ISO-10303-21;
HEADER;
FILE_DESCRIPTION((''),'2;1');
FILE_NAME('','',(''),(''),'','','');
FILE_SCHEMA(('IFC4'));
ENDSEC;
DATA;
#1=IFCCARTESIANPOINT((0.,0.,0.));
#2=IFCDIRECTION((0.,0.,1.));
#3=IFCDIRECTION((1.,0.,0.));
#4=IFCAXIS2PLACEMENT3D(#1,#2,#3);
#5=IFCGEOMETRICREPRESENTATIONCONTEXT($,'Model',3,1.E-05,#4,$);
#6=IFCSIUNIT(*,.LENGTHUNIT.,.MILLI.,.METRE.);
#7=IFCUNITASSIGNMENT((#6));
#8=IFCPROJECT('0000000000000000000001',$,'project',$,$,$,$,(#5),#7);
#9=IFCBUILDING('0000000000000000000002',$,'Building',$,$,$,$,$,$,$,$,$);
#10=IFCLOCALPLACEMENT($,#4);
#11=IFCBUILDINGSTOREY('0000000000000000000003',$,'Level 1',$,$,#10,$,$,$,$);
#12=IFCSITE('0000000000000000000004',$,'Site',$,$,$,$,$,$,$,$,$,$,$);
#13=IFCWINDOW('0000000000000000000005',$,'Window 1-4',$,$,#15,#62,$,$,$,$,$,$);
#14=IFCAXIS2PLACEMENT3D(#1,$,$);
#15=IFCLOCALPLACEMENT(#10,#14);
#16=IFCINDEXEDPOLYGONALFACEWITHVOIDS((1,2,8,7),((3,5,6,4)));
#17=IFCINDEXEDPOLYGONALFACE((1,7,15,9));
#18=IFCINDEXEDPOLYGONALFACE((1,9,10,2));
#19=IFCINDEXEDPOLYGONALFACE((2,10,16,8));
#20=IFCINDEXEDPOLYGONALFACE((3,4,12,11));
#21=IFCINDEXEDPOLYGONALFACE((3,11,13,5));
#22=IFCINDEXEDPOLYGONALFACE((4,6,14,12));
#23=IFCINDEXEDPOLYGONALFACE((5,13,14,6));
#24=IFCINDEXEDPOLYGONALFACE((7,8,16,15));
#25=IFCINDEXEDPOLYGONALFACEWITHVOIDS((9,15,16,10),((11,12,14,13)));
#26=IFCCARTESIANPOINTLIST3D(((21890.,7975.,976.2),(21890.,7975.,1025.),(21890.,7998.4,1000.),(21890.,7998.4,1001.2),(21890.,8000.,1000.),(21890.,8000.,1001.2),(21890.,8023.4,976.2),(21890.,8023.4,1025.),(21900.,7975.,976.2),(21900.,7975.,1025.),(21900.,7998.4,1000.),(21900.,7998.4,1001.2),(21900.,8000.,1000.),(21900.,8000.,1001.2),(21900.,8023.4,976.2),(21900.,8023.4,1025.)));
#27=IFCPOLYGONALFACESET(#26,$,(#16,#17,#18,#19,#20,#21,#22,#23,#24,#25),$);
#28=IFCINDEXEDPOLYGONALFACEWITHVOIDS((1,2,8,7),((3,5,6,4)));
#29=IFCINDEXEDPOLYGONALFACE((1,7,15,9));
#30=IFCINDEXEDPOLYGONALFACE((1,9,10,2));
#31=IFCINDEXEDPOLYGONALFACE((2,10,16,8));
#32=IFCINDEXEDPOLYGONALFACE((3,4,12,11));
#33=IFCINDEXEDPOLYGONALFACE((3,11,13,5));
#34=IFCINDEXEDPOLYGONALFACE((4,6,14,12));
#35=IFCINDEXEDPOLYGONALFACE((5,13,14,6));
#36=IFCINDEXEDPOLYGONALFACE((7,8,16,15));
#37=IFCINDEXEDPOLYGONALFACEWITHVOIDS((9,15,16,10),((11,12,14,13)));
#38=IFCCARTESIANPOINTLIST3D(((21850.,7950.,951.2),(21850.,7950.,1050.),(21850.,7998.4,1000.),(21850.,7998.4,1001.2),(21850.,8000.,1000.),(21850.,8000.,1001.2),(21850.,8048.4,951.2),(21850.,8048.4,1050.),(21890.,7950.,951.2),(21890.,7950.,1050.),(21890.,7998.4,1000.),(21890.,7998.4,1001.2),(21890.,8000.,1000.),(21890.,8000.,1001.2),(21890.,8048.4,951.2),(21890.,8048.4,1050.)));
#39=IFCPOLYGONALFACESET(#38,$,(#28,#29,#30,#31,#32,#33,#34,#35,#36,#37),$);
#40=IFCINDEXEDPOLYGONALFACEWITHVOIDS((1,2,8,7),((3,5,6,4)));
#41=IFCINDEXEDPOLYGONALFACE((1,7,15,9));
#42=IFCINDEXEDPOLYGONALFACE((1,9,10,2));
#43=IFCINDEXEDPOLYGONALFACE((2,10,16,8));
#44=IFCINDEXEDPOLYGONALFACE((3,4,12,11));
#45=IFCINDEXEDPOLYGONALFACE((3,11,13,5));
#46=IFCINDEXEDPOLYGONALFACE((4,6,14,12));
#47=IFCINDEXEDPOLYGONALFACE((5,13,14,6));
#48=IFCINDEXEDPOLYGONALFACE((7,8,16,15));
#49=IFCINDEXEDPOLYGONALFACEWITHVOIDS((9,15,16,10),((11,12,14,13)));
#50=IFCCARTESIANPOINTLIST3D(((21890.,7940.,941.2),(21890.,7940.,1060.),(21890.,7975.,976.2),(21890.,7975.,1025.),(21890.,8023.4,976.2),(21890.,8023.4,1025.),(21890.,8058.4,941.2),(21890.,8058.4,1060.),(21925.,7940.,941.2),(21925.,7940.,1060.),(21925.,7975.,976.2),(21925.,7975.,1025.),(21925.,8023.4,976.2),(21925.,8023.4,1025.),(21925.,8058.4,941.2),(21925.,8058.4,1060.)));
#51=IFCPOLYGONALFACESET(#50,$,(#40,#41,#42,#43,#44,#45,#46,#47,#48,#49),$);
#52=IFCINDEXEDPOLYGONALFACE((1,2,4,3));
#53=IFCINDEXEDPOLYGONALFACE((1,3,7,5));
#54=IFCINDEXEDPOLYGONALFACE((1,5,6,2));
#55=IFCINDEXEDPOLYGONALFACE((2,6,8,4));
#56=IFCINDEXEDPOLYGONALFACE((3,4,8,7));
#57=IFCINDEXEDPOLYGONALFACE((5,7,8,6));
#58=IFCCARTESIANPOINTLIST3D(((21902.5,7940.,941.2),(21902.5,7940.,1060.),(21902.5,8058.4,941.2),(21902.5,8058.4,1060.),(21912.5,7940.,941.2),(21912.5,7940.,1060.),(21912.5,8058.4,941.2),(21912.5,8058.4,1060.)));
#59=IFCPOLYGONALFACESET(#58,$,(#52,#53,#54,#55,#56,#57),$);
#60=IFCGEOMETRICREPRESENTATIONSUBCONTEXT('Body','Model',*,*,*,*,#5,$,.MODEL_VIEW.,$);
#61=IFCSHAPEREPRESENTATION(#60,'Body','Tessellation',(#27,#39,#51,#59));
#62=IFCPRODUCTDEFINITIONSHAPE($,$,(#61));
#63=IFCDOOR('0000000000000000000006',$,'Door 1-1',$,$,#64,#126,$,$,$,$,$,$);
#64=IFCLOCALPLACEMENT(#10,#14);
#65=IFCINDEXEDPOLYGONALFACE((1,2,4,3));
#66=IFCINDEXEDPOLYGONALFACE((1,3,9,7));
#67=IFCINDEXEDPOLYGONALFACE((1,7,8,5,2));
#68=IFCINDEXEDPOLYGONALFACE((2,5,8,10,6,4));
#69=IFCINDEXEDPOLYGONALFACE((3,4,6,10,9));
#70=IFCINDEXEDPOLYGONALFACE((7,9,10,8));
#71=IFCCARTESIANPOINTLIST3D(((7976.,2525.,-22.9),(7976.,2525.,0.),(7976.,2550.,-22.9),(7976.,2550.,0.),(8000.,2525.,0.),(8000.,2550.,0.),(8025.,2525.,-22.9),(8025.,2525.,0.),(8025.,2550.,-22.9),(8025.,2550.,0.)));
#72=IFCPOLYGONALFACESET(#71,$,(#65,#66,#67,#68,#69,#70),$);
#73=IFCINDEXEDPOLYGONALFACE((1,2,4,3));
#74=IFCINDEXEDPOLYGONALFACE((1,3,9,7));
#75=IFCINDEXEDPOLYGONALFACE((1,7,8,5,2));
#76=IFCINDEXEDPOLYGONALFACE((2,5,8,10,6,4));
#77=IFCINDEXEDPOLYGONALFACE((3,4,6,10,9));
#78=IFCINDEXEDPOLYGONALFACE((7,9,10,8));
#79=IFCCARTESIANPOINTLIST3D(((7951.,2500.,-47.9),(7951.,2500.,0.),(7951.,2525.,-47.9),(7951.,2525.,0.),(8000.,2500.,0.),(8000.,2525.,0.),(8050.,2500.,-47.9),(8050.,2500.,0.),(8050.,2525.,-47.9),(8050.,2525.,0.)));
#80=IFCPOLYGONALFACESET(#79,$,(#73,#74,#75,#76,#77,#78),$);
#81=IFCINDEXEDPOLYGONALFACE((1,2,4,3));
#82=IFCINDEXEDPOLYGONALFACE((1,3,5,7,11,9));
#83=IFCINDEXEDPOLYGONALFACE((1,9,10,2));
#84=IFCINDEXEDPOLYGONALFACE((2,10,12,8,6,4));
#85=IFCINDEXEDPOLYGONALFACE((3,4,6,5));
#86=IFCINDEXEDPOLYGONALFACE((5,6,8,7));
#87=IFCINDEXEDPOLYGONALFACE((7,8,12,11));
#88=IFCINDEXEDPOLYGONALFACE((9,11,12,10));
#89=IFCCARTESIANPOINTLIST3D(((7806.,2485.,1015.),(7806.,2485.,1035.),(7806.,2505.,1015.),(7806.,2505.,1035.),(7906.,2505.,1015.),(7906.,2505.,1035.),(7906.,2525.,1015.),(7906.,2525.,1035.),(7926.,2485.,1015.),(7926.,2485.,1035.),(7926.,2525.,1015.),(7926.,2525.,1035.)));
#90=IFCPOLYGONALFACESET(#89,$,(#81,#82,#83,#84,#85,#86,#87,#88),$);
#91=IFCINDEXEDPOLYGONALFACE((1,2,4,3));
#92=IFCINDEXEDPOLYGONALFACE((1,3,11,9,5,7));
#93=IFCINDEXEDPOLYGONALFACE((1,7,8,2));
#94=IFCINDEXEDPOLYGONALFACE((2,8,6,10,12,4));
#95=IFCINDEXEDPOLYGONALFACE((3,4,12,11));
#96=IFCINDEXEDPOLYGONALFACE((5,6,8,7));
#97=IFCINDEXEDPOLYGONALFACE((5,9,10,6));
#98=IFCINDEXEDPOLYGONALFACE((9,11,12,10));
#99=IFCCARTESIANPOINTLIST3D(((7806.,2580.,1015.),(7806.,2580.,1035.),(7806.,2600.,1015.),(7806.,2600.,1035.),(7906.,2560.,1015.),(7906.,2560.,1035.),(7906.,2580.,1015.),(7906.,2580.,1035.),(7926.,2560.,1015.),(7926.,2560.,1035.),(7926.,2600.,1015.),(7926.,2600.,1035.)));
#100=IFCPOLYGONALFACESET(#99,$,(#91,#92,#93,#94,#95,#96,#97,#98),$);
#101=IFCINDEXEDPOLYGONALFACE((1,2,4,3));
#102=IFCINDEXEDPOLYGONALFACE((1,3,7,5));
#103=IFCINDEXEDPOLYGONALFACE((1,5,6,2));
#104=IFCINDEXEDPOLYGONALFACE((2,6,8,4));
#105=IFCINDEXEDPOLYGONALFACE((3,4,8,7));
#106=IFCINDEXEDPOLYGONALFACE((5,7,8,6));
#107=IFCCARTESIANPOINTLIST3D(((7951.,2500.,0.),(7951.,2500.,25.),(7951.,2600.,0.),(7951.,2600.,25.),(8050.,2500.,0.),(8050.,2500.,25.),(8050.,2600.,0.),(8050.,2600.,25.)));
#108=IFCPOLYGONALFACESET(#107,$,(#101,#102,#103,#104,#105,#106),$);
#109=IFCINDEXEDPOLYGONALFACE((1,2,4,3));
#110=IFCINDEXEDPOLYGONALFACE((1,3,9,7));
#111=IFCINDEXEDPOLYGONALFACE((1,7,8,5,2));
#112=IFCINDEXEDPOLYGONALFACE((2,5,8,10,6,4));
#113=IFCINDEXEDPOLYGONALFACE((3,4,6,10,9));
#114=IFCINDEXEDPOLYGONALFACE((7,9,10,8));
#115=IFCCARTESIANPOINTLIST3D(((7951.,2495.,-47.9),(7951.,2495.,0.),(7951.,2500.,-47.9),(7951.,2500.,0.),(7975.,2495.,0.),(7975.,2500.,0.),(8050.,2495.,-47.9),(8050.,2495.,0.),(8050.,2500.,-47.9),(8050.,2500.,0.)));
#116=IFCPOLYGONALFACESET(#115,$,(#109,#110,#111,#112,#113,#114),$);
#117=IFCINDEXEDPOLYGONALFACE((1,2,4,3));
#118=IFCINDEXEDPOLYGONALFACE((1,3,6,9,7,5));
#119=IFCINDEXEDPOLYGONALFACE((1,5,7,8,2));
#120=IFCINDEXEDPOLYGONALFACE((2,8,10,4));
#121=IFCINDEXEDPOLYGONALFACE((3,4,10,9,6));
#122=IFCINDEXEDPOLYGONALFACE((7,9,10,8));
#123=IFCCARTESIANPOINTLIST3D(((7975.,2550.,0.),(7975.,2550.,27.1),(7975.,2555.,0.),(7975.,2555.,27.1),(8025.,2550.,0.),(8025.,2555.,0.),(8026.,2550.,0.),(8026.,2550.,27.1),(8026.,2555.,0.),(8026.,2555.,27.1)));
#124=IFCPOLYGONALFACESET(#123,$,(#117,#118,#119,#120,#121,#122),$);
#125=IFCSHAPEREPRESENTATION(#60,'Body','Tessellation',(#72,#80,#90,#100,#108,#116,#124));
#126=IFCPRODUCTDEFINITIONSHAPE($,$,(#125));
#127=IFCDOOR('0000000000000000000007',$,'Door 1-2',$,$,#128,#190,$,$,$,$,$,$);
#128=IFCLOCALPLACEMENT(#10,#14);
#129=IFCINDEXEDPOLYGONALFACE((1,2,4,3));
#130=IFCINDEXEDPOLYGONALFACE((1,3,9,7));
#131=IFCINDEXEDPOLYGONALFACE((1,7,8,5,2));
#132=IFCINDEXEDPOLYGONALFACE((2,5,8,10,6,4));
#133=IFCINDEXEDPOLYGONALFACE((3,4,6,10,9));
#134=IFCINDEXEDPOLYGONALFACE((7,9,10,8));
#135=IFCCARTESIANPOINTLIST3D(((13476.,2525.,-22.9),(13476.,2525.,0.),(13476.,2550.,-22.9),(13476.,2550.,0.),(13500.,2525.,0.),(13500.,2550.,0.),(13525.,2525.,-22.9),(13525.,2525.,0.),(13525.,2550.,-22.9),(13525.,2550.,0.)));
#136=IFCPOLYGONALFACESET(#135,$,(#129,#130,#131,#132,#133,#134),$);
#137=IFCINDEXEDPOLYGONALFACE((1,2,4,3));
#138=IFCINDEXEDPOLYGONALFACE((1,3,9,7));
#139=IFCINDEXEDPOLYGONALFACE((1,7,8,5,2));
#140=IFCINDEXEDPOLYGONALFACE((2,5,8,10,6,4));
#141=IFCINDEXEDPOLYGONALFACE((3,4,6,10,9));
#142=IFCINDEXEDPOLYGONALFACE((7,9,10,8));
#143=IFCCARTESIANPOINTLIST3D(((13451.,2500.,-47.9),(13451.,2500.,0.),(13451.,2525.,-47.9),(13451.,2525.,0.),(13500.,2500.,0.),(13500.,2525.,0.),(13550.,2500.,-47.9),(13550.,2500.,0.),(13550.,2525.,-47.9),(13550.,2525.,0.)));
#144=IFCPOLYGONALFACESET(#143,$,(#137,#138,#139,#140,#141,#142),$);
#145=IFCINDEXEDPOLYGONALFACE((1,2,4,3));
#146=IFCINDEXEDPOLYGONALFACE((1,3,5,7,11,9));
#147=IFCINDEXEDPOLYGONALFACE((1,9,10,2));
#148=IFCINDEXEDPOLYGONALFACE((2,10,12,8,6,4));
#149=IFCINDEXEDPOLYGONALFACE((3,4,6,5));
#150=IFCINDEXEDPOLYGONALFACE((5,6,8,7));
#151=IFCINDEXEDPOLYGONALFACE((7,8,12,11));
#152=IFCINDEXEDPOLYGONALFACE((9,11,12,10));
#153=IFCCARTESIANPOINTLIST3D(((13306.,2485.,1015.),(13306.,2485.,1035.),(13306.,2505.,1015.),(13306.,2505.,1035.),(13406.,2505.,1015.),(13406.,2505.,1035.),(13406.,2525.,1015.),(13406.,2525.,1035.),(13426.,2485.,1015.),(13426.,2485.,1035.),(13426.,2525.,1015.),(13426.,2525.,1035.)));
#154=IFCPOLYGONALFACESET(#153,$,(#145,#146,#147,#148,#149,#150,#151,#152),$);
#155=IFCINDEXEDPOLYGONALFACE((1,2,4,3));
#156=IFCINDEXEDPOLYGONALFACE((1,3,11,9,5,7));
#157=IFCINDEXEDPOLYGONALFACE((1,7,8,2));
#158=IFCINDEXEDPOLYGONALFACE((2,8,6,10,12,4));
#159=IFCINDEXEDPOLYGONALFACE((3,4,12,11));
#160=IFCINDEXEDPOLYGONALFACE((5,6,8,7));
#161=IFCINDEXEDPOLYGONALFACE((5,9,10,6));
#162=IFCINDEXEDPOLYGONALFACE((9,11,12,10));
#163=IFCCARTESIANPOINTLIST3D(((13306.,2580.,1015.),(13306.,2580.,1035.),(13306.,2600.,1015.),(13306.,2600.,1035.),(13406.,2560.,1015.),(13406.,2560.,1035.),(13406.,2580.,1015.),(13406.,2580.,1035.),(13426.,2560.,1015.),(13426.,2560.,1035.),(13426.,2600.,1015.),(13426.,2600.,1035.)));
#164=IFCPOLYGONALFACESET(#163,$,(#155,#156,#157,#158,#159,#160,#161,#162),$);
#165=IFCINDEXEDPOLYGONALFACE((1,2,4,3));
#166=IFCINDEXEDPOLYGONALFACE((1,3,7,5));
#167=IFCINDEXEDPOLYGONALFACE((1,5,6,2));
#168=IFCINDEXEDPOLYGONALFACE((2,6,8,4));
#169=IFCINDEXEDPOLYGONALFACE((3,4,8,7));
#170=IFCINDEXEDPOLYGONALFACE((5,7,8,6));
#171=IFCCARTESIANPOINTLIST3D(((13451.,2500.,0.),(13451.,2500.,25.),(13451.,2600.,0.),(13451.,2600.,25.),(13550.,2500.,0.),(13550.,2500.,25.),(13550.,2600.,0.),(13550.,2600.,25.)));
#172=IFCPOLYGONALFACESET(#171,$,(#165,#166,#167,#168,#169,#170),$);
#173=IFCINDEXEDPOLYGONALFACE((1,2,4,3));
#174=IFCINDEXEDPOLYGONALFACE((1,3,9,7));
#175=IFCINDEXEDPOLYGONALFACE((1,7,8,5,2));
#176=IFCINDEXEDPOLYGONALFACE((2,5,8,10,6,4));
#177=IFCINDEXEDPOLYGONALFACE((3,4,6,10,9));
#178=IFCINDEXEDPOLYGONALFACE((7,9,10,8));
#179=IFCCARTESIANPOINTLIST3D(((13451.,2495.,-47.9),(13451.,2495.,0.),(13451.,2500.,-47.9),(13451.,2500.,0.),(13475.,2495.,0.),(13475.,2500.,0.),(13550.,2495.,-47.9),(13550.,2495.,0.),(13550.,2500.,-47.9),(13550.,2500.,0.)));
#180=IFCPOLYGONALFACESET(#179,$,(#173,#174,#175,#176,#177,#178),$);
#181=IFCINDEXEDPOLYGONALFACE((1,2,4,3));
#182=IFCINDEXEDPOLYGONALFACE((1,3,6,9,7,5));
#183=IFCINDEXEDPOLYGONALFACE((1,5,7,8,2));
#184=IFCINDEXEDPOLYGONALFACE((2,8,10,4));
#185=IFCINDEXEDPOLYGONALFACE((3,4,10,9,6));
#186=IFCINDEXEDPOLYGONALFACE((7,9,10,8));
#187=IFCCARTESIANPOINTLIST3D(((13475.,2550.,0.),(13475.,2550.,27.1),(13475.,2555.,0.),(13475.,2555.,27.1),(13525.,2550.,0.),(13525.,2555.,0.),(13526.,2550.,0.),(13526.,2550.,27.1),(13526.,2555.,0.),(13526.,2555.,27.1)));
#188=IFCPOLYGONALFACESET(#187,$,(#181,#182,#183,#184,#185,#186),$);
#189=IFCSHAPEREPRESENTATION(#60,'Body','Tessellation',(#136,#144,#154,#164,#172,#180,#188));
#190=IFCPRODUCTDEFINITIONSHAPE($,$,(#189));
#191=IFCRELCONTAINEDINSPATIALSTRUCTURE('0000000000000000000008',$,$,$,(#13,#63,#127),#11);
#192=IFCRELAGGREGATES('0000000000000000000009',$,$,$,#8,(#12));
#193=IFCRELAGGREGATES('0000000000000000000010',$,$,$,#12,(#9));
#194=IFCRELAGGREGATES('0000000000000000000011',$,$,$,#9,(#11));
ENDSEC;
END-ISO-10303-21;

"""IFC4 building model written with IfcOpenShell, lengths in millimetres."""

from ifc_helpers import new_model, si_unit, frame, origin_with_axes, place, context, subcontext, project, spatial, line, indexed_curve, outline, extrude, element, save


model = new_model("IFC4")

# Units and contexts
model_context = context("Model", 3, precision=1e-05, world=origin_with_axes())
body_context = subcontext(model_context, "Body", "Model", "MODEL_VIEW")
ifc_project = project(units=[si_unit("LENGTHUNIT", "METRE", prefix="MILLI")], contexts=[model_context])

# Site, building, storey
site = spatial("IfcSite", under=ifc_project, Name="Site")
building = spatial("IfcBuilding", under=site, Name="Building")
storey_placement = place(None, origin_with_axes())
storey = spatial("IfcBuildingStorey", under=building, at=storey_placement, Name="Level 1")

# Window
for number, where, z_axis, x_axis, name in (
    (1, (21800.0, 8000.0, 1000.0), (0.0, 0.0, 1.0), (0.0, -1.0, 0.0), "Window 1-4"),
):
    element("IfcWindow", number, at=place(storey_placement, frame(where, z_axis=z_axis, x_axis=x_axis)), inside=storey, Name=name, context=body_context, shape_type="SweptSolid", body=[
        extrude(outline(indexed_curve([(0.0, 0.0), (1.6, 0.0), (1.6, 1.2), (0.0, 1.2)], segments=[line(1, 2, 3, 4, 1)]), holes=[indexed_curve([(25.0, 25.0), (-23.4, 25.0), (-23.4, -23.8), (25.0, -23.8)], segments=[line(1, 2, 3, 4, 1)])]), frame((0.0, 90.0, 0.0), z_axis=(0.0, -1.0, 0.0), x_axis=(1.0, 0.0, 0.0)), (0.0, 0.0, -1.0), 10.0),
        extrude(outline(indexed_curve([(0.0, 0.0), (1.6, 0.0), (1.6, 1.2), (0.0, 1.2)], segments=[line(1, 2, 3, 4, 1)]), holes=[indexed_curve([(50.0, 50.0), (-48.4, 50.0), (-48.4, -48.8), (50.0, -48.8)], segments=[line(1, 2, 3, 4, 1)])]), frame((0.0, 50.0, 0.0), z_axis=(0.0, -1.0, 0.0), x_axis=(1.0, 0.0, 0.0)), (0.0, 0.0, -1.0), 40.0),
        extrude(outline(indexed_curve([(0.0, 0.0), (-48.4, 0.0), (-48.4, -48.8), (0.0, -48.8)], segments=[line(1, 2, 3, 4, 1)]), holes=[indexed_curve([(35.0, 35.0), (-83.4, 35.0), (-83.4, -83.8), (35.0, -83.8)], segments=[line(1, 2, 3, 4, 1)])]), frame((25.0, 90.0, 25.0), z_axis=(0.0, -1.0, 0.0), x_axis=(1.0, 0.0, 0.0)), (0.0, 0.0, -1.0), 35.0),
        extrude(outline(indexed_curve([(35.0, 35.0), (-83.4, 35.0), (-83.4, -83.8), (35.0, -83.8)], segments=[line(1, 2, 3, 4, 1)])), frame((25.0, 102.5, 25.0), z_axis=(0.0, -1.0, 0.0), x_axis=(1.0, 0.0, 0.0)), (0.0, 0.0, -1.0), 10.0),
    ])

# Doors
door_1_placement = place(storey_placement, frame((8000.0, 2500.0, 0.0), z_axis=(0.0, 0.0, 1.0), x_axis=(1.0, 0.0, 0.0)))
element("IfcDoor", 2, at=door_1_placement, inside=storey, Name="Door 1-1", context=body_context, shape_type="SweptSolid", body=[
    extrude(outline(indexed_curve([(0.0, 0.0), (0.0, 2.1), (1.0, 2.1), (1.0, 0.0), (-24.0, 0.0), (-24.0, -22.9), (25.0, -22.9), (25.0, 0.0)], segments=[line(1, 2, 3, 4, 5, 6, 7, 8, 1)])), frame((0.0, 25.0, 0.0), z_axis=(0.0, -1.0, 0.0), x_axis=(1.0, 0.0, 0.0)), (0.0, 0.0, -1.0), 25.0),
    extrude(outline(indexed_curve([(0.0, 0.0), (0.0, 2.1), (1.0, 2.1), (1.0, 0.0), (-49.0, 0.0), (-49.0, -47.9), (50.0, -47.9), (50.0, 0.0)], segments=[line(1, 2, 3, 4, 5, 6, 7, 8, 1)])), frame((0.0, 0.0, 0.0), z_axis=(0.0, -1.0, 0.0), x_axis=(1.0, 0.0, 0.0)), (0.0, 0.0, -1.0), 25.0),
    extrude(outline(indexed_curve([(0.0, 0.0), (-49.0, 0.0), (-49.0, 35.0), (0.0, 35.0)], segments=[line(1, 2, 3, 4, 1)])), frame((25.0, 25.0, 25.0), z_axis=(0.0, 0.0, 1.0), x_axis=(1.0, 0.0, 0.0)), (0.0, 0.0, 1.0), -47.9),
    extrude(outline(indexed_curve([(0.0, 0.0), (0.0, -40.0), (-120.0, -40.0), (-120.0, -20.0), (-20.0, -20.0), (-20.0, 0.0)], segments=[line(1, 2, 3, 4, 5, 6, 1)])), frame((-74.0, 25.0, 1015.0), z_axis=(0.0, 0.0, 1.0), x_axis=(1.0, 0.0, 0.0)), (0.0, 0.0, 1.0), 20.0),
    extrude(outline(indexed_curve([(0.0, 0.0), (0.0, 40.0), (-120.0, 40.0), (-120.0, 20.0), (-20.0, 20.0), (-20.0, 0.0)], segments=[line(1, 2, 3, 4, 5, 6, 1)])), frame((-74.0, 60.0, 1015.0), z_axis=(0.0, 0.0, 1.0), x_axis=(1.0, 0.0, 0.0)), (0.0, 0.0, 1.0), 20.0),
    extrude(outline(indexed_curve([(0.0, 0.0), (-99.0, 0.0), (-99.0, 100.0), (0.0, 100.0)], segments=[line(1, 2, 3, 4, 1)])), frame((50.0, 0.0, 0.0), z_axis=(0.0, 0.0, 1.0), x_axis=(1.0, 0.0, 0.0)), (0.0, 0.0, 1.0), 25.0),
    extrude(outline(indexed_curve([(0.0, 0.0), (0.0, 27.1), (51.0, 27.1), (51.0, 0.0), (-24.0, 0.0), (-24.0, -47.9), (75.0, -47.9), (75.0, 0.0)], segments=[line(1, 2, 3, 4, 5, 6, 7, 8, 1)])), frame((-25.0, -5.0, 0.0), z_axis=(0.0, -1.0, 0.0), x_axis=(1.0, 0.0, 0.0)), (0.0, 0.0, -1.0), 5.0),
    extrude(outline(indexed_curve([(0.0, 0.0), (0.0, 27.1), (51.0, 27.1), (51.0, 0.0), (1.0, 0.0), (1.0, -22.9), (50.0, -22.9), (50.0, 0.0)], segments=[line(1, 2, 3, 4, 5, 6, 7, 8, 1)])), frame((-25.0, 50.0, 0.0), z_axis=(0.0, -1.0, 0.0), x_axis=(1.0, 0.0, 0.0)), (0.0, 0.0, -1.0), 5.0),
])
door_2_placement = place(storey_placement, frame((13500.0, 2500.0, 0.0), z_axis=(0.0, 0.0, 1.0), x_axis=(1.0, 0.0, 0.0)))
element("IfcDoor", 3, at=door_2_placement, inside=storey, Name="Door 1-2", context=body_context, shape_type="SweptSolid", body=[
    extrude(outline(indexed_curve([(0.0, 0.0), (0.0, 2.1), (1.0, 2.1), (1.0, 0.0), (-24.0, 0.0), (-24.0, -22.9), (25.0, -22.9), (25.0, 0.0)], segments=[line(1, 2, 3, 4, 5, 6, 7, 8, 1)])), frame((0.0, 25.0, 0.0), z_axis=(0.0, -1.0, 0.0), x_axis=(1.0, 0.0, 0.0)), (0.0, 0.0, -1.0), 25.0),
    extrude(outline(indexed_curve([(0.0, 0.0), (0.0, 2.1), (1.0, 2.1), (1.0, 0.0), (-49.0, 0.0), (-49.0, -47.9), (50.0, -47.9), (50.0, 0.0)], segments=[line(1, 2, 3, 4, 5, 6, 7, 8, 1)])), frame((0.0, 0.0, 0.0), z_axis=(0.0, -1.0, 0.0), x_axis=(1.0, 0.0, 0.0)), (0.0, 0.0, -1.0), 25.0),
    extrude(outline(indexed_curve([(0.0, 0.0), (-49.0, 0.0), (-49.0, 35.0), (0.0, 35.0)], segments=[line(1, 2, 3, 4, 1)])), frame((25.0, 25.0, 25.0), z_axis=(0.0, 0.0, 1.0), x_axis=(1.0, 0.0, 0.0)), (0.0, 0.0, 1.0), -47.9),
    extrude(outline(indexed_curve([(0.0, 0.0), (0.0, -40.0), (-120.0, -40.0), (-120.0, -20.0), (-20.0, -20.0), (-20.0, 0.0)], segments=[line(1, 2, 3, 4, 5, 6, 1)])), frame((-74.0, 25.0, 1015.0), z_axis=(0.0, 0.0, 1.0), x_axis=(1.0, 0.0, 0.0)), (0.0, 0.0, 1.0), 20.0),
    extrude(outline(indexed_curve([(0.0, 0.0), (0.0, 40.0), (-120.0, 40.0), (-120.0, 20.0), (-20.0, 20.0), (-20.0, 0.0)], segments=[line(1, 2, 3, 4, 5, 6, 1)])), frame((-74.0, 60.0, 1015.0), z_axis=(0.0, 0.0, 1.0), x_axis=(1.0, 0.0, 0.0)), (0.0, 0.0, 1.0), 20.0),
    extrude(outline(indexed_curve([(0.0, 0.0), (-99.0, 0.0), (-99.0, 100.0), (0.0, 100.0)], segments=[line(1, 2, 3, 4, 1)])), frame((50.0, 0.0, 0.0), z_axis=(0.0, 0.0, 1.0), x_axis=(1.0, 0.0, 0.0)), (0.0, 0.0, 1.0), 25.0),
    extrude(outline(indexed_curve([(0.0, 0.0), (0.0, 27.1), (51.0, 27.1), (51.0, 0.0), (-24.0, 0.0), (-24.0, -47.9), (75.0, -47.9), (75.0, 0.0)], segments=[line(1, 2, 3, 4, 5, 6, 7, 8, 1)])), frame((-25.0, -5.0, 0.0), z_axis=(0.0, -1.0, 0.0), x_axis=(1.0, 0.0, 0.0)), (0.0, 0.0, -1.0), 5.0),
    extrude(outline(indexed_curve([(0.0, 0.0), (0.0, 27.1), (51.0, 27.1), (51.0, 0.0), (1.0, 0.0), (1.0, -22.9), (50.0, -22.9), (50.0, 0.0)], segments=[line(1, 2, 3, 4, 5, 6, 7, 8, 1)])), frame((-25.0, 50.0, 0.0), z_axis=(0.0, -1.0, 0.0), x_axis=(1.0, 0.0, 0.0)), (0.0, 0.0, -1.0), 5.0),
])

save(model, "model.ifc")
